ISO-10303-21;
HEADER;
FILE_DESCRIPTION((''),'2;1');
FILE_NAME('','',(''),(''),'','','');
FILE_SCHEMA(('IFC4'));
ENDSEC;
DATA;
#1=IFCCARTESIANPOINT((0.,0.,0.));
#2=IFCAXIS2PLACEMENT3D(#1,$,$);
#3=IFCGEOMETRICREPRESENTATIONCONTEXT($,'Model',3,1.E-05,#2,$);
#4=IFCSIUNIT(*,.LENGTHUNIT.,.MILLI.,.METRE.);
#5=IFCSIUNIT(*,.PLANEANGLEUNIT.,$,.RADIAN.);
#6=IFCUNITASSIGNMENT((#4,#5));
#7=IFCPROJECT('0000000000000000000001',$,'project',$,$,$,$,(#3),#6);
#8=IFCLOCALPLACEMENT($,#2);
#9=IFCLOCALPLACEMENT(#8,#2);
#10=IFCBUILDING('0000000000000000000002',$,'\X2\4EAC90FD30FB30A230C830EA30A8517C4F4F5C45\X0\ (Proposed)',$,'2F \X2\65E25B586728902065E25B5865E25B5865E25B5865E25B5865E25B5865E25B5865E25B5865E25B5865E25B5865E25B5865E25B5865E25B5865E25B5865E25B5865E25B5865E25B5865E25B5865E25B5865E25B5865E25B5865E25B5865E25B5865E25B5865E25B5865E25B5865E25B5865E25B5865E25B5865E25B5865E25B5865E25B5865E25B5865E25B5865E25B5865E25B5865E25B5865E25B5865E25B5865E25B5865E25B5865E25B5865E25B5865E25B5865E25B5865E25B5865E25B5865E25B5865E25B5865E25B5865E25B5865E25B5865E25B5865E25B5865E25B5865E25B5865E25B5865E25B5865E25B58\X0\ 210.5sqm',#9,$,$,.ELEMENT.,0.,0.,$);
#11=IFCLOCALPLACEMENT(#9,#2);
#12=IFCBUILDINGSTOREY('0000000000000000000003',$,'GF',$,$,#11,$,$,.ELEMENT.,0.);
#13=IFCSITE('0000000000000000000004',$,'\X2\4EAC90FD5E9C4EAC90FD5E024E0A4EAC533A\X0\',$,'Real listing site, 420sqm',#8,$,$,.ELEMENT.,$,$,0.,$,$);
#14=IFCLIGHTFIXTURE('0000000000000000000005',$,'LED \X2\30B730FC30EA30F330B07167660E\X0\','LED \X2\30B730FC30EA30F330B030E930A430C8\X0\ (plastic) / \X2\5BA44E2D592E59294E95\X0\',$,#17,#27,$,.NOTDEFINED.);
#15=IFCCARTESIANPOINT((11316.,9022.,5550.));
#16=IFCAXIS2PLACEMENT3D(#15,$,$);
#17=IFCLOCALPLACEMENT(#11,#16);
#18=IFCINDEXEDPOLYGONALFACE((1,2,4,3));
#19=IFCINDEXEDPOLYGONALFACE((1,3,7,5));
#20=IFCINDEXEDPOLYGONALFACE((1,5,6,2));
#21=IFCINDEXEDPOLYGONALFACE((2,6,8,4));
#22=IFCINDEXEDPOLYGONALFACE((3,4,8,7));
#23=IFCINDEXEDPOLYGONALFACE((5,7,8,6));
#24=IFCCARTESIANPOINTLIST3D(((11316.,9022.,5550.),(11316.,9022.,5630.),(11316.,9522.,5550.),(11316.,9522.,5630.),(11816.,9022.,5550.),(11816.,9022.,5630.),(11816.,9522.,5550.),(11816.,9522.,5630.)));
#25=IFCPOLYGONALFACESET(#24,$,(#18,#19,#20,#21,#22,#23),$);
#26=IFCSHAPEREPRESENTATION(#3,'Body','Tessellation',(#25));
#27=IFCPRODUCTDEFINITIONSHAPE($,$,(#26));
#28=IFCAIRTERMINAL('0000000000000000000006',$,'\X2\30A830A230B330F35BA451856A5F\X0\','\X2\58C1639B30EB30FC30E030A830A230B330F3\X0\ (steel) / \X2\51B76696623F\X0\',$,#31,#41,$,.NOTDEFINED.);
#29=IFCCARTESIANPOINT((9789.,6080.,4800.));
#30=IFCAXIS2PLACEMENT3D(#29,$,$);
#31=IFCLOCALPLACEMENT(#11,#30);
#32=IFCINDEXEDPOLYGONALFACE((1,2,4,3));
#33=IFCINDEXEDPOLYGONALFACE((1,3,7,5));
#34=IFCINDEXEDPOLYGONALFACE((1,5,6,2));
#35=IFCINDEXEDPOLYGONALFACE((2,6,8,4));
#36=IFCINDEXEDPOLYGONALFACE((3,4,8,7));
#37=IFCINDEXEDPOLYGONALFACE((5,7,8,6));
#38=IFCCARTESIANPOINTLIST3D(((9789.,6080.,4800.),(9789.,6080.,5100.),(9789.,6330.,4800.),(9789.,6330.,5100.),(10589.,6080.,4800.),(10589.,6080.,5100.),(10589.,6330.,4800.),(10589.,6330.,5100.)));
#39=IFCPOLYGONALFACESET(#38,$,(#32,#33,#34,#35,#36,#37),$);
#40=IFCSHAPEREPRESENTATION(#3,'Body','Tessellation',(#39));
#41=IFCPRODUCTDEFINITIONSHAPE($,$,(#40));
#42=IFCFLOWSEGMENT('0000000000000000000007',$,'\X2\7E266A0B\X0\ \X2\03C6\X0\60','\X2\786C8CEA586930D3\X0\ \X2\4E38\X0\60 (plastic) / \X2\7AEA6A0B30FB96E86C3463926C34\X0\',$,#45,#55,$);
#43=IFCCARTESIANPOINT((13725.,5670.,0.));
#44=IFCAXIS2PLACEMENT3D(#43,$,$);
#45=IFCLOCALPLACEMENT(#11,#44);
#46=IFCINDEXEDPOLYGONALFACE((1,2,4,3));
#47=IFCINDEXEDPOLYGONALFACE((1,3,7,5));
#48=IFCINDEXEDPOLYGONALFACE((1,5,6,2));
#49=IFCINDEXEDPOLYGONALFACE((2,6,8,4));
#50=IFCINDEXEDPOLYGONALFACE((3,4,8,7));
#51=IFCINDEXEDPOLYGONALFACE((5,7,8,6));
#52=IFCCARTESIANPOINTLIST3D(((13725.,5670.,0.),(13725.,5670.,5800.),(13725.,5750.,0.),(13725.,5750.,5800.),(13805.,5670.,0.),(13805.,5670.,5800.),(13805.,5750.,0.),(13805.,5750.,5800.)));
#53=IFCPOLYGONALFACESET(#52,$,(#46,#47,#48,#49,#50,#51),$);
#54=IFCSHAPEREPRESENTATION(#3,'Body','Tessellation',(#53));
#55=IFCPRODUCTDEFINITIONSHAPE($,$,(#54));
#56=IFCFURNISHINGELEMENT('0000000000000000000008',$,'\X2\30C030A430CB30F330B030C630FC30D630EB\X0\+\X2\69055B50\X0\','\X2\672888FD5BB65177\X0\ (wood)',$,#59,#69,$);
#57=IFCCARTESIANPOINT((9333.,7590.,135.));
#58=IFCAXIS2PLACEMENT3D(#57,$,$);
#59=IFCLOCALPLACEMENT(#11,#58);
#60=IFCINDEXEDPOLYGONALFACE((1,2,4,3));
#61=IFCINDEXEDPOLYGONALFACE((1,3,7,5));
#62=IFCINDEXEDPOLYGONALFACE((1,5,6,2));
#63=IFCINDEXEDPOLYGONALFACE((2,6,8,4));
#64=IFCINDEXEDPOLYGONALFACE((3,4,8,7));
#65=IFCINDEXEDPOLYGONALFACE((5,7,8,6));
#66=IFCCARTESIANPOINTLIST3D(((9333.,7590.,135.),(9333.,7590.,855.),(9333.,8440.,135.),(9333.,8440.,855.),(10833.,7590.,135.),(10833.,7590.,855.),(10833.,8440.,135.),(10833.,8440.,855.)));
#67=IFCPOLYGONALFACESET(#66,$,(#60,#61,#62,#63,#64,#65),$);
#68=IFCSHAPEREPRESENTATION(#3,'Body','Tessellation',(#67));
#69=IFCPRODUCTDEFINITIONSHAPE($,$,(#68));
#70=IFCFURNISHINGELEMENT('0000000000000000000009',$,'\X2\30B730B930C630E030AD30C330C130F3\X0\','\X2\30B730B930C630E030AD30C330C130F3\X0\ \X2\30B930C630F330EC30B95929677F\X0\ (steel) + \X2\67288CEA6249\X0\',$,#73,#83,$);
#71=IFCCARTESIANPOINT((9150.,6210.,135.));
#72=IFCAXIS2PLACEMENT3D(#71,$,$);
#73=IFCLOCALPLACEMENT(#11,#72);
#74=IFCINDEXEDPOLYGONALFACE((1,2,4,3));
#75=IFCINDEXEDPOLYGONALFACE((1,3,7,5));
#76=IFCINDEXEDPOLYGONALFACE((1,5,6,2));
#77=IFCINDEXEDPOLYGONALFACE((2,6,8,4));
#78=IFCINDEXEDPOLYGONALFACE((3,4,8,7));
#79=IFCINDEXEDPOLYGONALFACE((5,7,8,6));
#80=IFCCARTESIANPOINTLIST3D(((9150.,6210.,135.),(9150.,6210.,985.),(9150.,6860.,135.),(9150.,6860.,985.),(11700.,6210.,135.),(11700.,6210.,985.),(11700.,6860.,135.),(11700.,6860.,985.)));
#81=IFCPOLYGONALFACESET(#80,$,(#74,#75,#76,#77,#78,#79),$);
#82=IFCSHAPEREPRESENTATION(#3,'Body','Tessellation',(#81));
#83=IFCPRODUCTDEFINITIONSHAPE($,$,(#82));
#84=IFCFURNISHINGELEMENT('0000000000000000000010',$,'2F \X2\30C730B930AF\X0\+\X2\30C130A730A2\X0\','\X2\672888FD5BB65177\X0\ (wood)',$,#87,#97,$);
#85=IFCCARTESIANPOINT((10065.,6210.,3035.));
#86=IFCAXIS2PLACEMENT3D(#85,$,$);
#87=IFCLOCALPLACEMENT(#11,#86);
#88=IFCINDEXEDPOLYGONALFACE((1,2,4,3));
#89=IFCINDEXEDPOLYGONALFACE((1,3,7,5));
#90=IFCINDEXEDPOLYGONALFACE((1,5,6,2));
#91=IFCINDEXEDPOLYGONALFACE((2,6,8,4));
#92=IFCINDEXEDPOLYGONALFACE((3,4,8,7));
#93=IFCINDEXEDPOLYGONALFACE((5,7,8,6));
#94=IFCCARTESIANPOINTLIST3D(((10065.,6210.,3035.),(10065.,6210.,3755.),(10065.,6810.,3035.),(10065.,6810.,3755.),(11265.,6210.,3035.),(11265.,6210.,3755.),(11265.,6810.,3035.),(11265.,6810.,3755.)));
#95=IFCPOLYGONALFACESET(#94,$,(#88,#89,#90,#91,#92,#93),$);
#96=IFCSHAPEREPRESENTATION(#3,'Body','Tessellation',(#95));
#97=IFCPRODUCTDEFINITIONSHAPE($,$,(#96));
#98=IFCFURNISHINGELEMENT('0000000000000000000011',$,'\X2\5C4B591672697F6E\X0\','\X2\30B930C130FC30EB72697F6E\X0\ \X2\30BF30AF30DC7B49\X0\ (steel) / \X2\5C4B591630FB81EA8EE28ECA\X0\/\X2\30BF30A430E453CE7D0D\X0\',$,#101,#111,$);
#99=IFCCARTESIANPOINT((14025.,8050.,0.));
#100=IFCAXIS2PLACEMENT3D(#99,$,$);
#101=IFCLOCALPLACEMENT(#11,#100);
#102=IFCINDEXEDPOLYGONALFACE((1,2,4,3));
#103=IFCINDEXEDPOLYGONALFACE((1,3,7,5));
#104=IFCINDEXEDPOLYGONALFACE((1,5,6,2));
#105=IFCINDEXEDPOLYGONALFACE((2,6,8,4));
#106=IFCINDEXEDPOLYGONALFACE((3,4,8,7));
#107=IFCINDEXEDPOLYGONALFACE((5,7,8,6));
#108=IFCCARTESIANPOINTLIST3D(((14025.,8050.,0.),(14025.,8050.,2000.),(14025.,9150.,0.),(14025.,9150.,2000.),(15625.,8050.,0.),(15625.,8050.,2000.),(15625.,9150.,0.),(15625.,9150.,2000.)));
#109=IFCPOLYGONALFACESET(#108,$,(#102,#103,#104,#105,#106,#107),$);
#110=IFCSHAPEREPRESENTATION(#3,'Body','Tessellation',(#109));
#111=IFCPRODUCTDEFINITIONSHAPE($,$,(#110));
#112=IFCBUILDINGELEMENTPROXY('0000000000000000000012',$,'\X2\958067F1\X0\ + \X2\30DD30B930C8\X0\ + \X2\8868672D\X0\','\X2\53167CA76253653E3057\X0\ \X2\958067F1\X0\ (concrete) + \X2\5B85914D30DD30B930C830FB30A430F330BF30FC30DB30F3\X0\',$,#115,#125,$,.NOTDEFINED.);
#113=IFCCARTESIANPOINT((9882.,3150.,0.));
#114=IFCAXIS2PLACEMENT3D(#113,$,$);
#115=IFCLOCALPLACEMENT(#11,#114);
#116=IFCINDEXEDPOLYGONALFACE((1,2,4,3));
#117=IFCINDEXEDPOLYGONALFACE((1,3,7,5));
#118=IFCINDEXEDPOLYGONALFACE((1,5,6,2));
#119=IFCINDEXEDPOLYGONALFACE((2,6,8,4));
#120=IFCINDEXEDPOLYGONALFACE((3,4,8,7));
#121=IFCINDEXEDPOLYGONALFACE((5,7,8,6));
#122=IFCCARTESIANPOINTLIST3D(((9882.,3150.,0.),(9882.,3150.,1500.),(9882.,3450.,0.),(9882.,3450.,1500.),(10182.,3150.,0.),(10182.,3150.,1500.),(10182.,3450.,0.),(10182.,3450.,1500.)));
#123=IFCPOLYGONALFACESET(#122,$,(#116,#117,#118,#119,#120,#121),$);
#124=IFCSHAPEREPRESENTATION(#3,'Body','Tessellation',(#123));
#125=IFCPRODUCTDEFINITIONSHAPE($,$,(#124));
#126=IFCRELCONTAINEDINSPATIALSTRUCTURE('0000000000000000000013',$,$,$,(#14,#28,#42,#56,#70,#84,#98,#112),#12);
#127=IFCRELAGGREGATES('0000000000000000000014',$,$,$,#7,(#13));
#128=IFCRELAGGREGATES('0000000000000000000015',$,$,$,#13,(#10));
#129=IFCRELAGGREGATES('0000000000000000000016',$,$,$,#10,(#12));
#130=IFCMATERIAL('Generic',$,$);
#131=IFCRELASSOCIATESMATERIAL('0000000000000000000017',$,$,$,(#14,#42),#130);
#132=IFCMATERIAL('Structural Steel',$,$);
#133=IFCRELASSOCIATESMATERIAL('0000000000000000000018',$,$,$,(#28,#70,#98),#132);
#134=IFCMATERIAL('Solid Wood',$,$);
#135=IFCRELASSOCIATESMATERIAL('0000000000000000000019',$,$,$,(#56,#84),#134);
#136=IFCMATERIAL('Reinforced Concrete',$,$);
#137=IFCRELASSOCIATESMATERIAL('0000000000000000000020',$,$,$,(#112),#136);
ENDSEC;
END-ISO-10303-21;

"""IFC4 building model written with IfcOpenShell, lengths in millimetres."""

from ifc_helpers import new_model, si_unit, frame, frame_2d, origin, place, context, project, spatial, rectangle, extrude, material, element, save


model = new_model("IFC4")

# Units and contexts
model_context = context("Model", 3, precision=1e-05, world=origin())
ifc_project = project(units=[si_unit("LENGTHUNIT", "METRE", prefix="MILLI"), si_unit("PLANEANGLEUNIT", "RADIAN")], contexts=[model_context])

# Site, building, storey
site_placement = place(None, origin())
site = spatial("IfcSite", under=ifc_project, at=site_placement, Name="京都府京都市上京区", ObjectType="Real listing site, 420sqm", CompositionType="ELEMENT", RefElevation=0.0)
building_placement = place(site_placement, origin())
building = spatial("IfcBuilding", under=site, at=building_placement, Name="京都・アトリエ兼住居 (Proposed)", ObjectType="2F 既存木造既存既存既存既存既存既存既存既存既存既存既存既存既存既存既存既存既存既存既存既存既存既存既存既存既存既存既存既存既存既存既存既存既存既存既存既存既存既存既存既存既存既存既存既存既存既存既存既存既存既存既存既存既存既存既存既存既存既存 210.5sqm", CompositionType="ELEMENT", ElevationOfRefHeight=0.0, ElevationOfTerrain=0.0)
storey_placement = place(building_placement, origin())
storey = spatial("IfcBuildingStorey", under=building, at=storey_placement, Name="GF", CompositionType="ELEMENT", Elevation=0.0)

# Shared definitions
ifc_material_1 = material(Name="Solid Wood")

# Shared definitions
ifc_material_2 = material(Name="Reinforced Concrete")

# Shared definitions
ifc_material_3 = material(Name="Structural Steel")

# Shared definitions
ifc_material_4 = material(Name="Generic")

# Light fixture
light_fixture_placement = place(storey_placement, frame((11316.0, 9022.0, 5550.0)))
element("IfcLightFixture", 1, at=light_fixture_placement, inside=storey, material=ifc_material_4, Name="LED シーリング照明", Description="LED シーリングライト (plastic) / 室中央天井", PredefinedType="NOTDEFINED", context=model_context, shape_type="SweptSolid", body=[
    extrude(rectangle(XDim=500.0, YDim=500.0, at=frame_2d((250.0, 250.0))), frame((11316.0, 9022.0, 5550.0)), (0.0, 0.0, 1.0), 80.0),
])

# Air terminal
air_terminal_placement = place(storey_placement, frame((9789.0, 6080.0, 4800.0)))
element("IfcAirTerminal", 2, at=air_terminal_placement, inside=storey, material=ifc_material_3, Name="エアコン室内機", Description="壁掛ルームエアコン (steel) / 冷暖房", PredefinedType="NOTDEFINED", context=model_context, shape_type="SweptSolid", body=[
    extrude(rectangle(XDim=800.0, YDim=250.0, at=frame_2d((400.0, 125.0))), frame((9789.0, 6080.0, 4800.0)), (0.0, 0.0, 1.0), 300.0),
])

# Flow segment
flow_segment_placement = place(storey_placement, frame((13725.0, 5670.0, 0.0)))
element("IfcFlowSegment", 3, at=flow_segment_placement, inside=storey, material=ifc_material_4, Name="縦樋 φ60", Description="硬質塩ビ 丸60 (plastic) / 竪樋・雨水排水", context=model_context, shape_type="SweptSolid", body=[
    extrude(rectangle(XDim=80.0, YDim=80.0, at=frame_2d((40.0, 40.0))), frame((13725.0, 5670.0, 0.0)), (0.0, 0.0, 1.0), 5800.0),
])

# Furnishing elements
furnishing_1_placement = place(storey_placement, frame((9333.0, 7590.0, 135.0)))
element("IfcFurnishingElement", 4, at=furnishing_1_placement, inside=storey, material=ifc_material_1, Name="ダイニングテーブル+椅子", Description="木製家具 (wood)", context=model_context, shape_type="SweptSolid", body=[
    extrude(rectangle(XDim=1500.0, YDim=850.0, at=frame_2d((750.0, 425.0))), frame((9333.0, 7590.0, 135.0)), (0.0, 0.0, 1.0), 720.0),
])
furnishing_2_placement = place(storey_placement, frame((9150.0, 6210.0, 135.0)))
element("IfcFurnishingElement", 5, at=furnishing_2_placement, inside=storey, material=ifc_material_3, Name="システムキッチン", Description="システムキッチン ステンレス天板 (steel) + 木質扉", context=model_context, shape_type="SweptSolid", body=[
    extrude(rectangle(XDim=2550.0, YDim=650.0, at=frame_2d((1275.0, 325.0))), frame((9150.0, 6210.0, 135.0)), (0.0, 0.0, 1.0), 850.0),
])
furnishing_3_placement = place(storey_placement, frame((10065.0, 6210.0, 3035.0)))
element("IfcFurnishingElement", 6, at=furnishing_3_placement, inside=storey, material=ifc_material_1, Name="2F デスク+チェア", Description="木製家具 (wood)", context=model_context, shape_type="SweptSolid", body=[
    extrude(rectangle(XDim=1200.0, YDim=600.0, at=frame_2d((600.0, 300.0))), frame((10065.0, 6210.0, 3035.0)), (0.0, 0.0, 1.0), 720.0),
])
furnishing_4_placement = place(storey_placement, frame((14025.0, 8050.0, 0.0)))
element("IfcFurnishingElement", 7, at=furnishing_4_placement, inside=storey, material=ifc_material_3, Name="屋外物置", Description="スチール物置 タクボ等 (steel) / 屋外・自転車/タイヤ収納", context=model_context, shape_type="SweptSolid", body=[
    extrude(rectangle(XDim=1600.0, YDim=1100.0, at=frame_2d((800.0, 550.0))), frame((14025.0, 8050.0, 0.0)), (0.0, 0.0, 1.0), 2000.0),
])

# Building element proxy
proxy_placement = place(storey_placement, frame((9882.0, 3150.0, 0.0)))
element("IfcBuildingElementProxy", 8, at=proxy_placement, inside=storey, material=ifc_material_2, Name="門柱 + ポスト + 表札", Description="化粧打放し 門柱 (concrete) + 宅配ポスト・インターホン", PredefinedType="NOTDEFINED", context=model_context, shape_type="SweptSolid", body=[
    extrude(rectangle(XDim=300.0, YDim=300.0, at=frame_2d((150.0, 150.0))), frame((9882.0, 3150.0, 0.0)), (0.0, 0.0, 1.0), 1500.0),
])

save(model, "model.ifc")
